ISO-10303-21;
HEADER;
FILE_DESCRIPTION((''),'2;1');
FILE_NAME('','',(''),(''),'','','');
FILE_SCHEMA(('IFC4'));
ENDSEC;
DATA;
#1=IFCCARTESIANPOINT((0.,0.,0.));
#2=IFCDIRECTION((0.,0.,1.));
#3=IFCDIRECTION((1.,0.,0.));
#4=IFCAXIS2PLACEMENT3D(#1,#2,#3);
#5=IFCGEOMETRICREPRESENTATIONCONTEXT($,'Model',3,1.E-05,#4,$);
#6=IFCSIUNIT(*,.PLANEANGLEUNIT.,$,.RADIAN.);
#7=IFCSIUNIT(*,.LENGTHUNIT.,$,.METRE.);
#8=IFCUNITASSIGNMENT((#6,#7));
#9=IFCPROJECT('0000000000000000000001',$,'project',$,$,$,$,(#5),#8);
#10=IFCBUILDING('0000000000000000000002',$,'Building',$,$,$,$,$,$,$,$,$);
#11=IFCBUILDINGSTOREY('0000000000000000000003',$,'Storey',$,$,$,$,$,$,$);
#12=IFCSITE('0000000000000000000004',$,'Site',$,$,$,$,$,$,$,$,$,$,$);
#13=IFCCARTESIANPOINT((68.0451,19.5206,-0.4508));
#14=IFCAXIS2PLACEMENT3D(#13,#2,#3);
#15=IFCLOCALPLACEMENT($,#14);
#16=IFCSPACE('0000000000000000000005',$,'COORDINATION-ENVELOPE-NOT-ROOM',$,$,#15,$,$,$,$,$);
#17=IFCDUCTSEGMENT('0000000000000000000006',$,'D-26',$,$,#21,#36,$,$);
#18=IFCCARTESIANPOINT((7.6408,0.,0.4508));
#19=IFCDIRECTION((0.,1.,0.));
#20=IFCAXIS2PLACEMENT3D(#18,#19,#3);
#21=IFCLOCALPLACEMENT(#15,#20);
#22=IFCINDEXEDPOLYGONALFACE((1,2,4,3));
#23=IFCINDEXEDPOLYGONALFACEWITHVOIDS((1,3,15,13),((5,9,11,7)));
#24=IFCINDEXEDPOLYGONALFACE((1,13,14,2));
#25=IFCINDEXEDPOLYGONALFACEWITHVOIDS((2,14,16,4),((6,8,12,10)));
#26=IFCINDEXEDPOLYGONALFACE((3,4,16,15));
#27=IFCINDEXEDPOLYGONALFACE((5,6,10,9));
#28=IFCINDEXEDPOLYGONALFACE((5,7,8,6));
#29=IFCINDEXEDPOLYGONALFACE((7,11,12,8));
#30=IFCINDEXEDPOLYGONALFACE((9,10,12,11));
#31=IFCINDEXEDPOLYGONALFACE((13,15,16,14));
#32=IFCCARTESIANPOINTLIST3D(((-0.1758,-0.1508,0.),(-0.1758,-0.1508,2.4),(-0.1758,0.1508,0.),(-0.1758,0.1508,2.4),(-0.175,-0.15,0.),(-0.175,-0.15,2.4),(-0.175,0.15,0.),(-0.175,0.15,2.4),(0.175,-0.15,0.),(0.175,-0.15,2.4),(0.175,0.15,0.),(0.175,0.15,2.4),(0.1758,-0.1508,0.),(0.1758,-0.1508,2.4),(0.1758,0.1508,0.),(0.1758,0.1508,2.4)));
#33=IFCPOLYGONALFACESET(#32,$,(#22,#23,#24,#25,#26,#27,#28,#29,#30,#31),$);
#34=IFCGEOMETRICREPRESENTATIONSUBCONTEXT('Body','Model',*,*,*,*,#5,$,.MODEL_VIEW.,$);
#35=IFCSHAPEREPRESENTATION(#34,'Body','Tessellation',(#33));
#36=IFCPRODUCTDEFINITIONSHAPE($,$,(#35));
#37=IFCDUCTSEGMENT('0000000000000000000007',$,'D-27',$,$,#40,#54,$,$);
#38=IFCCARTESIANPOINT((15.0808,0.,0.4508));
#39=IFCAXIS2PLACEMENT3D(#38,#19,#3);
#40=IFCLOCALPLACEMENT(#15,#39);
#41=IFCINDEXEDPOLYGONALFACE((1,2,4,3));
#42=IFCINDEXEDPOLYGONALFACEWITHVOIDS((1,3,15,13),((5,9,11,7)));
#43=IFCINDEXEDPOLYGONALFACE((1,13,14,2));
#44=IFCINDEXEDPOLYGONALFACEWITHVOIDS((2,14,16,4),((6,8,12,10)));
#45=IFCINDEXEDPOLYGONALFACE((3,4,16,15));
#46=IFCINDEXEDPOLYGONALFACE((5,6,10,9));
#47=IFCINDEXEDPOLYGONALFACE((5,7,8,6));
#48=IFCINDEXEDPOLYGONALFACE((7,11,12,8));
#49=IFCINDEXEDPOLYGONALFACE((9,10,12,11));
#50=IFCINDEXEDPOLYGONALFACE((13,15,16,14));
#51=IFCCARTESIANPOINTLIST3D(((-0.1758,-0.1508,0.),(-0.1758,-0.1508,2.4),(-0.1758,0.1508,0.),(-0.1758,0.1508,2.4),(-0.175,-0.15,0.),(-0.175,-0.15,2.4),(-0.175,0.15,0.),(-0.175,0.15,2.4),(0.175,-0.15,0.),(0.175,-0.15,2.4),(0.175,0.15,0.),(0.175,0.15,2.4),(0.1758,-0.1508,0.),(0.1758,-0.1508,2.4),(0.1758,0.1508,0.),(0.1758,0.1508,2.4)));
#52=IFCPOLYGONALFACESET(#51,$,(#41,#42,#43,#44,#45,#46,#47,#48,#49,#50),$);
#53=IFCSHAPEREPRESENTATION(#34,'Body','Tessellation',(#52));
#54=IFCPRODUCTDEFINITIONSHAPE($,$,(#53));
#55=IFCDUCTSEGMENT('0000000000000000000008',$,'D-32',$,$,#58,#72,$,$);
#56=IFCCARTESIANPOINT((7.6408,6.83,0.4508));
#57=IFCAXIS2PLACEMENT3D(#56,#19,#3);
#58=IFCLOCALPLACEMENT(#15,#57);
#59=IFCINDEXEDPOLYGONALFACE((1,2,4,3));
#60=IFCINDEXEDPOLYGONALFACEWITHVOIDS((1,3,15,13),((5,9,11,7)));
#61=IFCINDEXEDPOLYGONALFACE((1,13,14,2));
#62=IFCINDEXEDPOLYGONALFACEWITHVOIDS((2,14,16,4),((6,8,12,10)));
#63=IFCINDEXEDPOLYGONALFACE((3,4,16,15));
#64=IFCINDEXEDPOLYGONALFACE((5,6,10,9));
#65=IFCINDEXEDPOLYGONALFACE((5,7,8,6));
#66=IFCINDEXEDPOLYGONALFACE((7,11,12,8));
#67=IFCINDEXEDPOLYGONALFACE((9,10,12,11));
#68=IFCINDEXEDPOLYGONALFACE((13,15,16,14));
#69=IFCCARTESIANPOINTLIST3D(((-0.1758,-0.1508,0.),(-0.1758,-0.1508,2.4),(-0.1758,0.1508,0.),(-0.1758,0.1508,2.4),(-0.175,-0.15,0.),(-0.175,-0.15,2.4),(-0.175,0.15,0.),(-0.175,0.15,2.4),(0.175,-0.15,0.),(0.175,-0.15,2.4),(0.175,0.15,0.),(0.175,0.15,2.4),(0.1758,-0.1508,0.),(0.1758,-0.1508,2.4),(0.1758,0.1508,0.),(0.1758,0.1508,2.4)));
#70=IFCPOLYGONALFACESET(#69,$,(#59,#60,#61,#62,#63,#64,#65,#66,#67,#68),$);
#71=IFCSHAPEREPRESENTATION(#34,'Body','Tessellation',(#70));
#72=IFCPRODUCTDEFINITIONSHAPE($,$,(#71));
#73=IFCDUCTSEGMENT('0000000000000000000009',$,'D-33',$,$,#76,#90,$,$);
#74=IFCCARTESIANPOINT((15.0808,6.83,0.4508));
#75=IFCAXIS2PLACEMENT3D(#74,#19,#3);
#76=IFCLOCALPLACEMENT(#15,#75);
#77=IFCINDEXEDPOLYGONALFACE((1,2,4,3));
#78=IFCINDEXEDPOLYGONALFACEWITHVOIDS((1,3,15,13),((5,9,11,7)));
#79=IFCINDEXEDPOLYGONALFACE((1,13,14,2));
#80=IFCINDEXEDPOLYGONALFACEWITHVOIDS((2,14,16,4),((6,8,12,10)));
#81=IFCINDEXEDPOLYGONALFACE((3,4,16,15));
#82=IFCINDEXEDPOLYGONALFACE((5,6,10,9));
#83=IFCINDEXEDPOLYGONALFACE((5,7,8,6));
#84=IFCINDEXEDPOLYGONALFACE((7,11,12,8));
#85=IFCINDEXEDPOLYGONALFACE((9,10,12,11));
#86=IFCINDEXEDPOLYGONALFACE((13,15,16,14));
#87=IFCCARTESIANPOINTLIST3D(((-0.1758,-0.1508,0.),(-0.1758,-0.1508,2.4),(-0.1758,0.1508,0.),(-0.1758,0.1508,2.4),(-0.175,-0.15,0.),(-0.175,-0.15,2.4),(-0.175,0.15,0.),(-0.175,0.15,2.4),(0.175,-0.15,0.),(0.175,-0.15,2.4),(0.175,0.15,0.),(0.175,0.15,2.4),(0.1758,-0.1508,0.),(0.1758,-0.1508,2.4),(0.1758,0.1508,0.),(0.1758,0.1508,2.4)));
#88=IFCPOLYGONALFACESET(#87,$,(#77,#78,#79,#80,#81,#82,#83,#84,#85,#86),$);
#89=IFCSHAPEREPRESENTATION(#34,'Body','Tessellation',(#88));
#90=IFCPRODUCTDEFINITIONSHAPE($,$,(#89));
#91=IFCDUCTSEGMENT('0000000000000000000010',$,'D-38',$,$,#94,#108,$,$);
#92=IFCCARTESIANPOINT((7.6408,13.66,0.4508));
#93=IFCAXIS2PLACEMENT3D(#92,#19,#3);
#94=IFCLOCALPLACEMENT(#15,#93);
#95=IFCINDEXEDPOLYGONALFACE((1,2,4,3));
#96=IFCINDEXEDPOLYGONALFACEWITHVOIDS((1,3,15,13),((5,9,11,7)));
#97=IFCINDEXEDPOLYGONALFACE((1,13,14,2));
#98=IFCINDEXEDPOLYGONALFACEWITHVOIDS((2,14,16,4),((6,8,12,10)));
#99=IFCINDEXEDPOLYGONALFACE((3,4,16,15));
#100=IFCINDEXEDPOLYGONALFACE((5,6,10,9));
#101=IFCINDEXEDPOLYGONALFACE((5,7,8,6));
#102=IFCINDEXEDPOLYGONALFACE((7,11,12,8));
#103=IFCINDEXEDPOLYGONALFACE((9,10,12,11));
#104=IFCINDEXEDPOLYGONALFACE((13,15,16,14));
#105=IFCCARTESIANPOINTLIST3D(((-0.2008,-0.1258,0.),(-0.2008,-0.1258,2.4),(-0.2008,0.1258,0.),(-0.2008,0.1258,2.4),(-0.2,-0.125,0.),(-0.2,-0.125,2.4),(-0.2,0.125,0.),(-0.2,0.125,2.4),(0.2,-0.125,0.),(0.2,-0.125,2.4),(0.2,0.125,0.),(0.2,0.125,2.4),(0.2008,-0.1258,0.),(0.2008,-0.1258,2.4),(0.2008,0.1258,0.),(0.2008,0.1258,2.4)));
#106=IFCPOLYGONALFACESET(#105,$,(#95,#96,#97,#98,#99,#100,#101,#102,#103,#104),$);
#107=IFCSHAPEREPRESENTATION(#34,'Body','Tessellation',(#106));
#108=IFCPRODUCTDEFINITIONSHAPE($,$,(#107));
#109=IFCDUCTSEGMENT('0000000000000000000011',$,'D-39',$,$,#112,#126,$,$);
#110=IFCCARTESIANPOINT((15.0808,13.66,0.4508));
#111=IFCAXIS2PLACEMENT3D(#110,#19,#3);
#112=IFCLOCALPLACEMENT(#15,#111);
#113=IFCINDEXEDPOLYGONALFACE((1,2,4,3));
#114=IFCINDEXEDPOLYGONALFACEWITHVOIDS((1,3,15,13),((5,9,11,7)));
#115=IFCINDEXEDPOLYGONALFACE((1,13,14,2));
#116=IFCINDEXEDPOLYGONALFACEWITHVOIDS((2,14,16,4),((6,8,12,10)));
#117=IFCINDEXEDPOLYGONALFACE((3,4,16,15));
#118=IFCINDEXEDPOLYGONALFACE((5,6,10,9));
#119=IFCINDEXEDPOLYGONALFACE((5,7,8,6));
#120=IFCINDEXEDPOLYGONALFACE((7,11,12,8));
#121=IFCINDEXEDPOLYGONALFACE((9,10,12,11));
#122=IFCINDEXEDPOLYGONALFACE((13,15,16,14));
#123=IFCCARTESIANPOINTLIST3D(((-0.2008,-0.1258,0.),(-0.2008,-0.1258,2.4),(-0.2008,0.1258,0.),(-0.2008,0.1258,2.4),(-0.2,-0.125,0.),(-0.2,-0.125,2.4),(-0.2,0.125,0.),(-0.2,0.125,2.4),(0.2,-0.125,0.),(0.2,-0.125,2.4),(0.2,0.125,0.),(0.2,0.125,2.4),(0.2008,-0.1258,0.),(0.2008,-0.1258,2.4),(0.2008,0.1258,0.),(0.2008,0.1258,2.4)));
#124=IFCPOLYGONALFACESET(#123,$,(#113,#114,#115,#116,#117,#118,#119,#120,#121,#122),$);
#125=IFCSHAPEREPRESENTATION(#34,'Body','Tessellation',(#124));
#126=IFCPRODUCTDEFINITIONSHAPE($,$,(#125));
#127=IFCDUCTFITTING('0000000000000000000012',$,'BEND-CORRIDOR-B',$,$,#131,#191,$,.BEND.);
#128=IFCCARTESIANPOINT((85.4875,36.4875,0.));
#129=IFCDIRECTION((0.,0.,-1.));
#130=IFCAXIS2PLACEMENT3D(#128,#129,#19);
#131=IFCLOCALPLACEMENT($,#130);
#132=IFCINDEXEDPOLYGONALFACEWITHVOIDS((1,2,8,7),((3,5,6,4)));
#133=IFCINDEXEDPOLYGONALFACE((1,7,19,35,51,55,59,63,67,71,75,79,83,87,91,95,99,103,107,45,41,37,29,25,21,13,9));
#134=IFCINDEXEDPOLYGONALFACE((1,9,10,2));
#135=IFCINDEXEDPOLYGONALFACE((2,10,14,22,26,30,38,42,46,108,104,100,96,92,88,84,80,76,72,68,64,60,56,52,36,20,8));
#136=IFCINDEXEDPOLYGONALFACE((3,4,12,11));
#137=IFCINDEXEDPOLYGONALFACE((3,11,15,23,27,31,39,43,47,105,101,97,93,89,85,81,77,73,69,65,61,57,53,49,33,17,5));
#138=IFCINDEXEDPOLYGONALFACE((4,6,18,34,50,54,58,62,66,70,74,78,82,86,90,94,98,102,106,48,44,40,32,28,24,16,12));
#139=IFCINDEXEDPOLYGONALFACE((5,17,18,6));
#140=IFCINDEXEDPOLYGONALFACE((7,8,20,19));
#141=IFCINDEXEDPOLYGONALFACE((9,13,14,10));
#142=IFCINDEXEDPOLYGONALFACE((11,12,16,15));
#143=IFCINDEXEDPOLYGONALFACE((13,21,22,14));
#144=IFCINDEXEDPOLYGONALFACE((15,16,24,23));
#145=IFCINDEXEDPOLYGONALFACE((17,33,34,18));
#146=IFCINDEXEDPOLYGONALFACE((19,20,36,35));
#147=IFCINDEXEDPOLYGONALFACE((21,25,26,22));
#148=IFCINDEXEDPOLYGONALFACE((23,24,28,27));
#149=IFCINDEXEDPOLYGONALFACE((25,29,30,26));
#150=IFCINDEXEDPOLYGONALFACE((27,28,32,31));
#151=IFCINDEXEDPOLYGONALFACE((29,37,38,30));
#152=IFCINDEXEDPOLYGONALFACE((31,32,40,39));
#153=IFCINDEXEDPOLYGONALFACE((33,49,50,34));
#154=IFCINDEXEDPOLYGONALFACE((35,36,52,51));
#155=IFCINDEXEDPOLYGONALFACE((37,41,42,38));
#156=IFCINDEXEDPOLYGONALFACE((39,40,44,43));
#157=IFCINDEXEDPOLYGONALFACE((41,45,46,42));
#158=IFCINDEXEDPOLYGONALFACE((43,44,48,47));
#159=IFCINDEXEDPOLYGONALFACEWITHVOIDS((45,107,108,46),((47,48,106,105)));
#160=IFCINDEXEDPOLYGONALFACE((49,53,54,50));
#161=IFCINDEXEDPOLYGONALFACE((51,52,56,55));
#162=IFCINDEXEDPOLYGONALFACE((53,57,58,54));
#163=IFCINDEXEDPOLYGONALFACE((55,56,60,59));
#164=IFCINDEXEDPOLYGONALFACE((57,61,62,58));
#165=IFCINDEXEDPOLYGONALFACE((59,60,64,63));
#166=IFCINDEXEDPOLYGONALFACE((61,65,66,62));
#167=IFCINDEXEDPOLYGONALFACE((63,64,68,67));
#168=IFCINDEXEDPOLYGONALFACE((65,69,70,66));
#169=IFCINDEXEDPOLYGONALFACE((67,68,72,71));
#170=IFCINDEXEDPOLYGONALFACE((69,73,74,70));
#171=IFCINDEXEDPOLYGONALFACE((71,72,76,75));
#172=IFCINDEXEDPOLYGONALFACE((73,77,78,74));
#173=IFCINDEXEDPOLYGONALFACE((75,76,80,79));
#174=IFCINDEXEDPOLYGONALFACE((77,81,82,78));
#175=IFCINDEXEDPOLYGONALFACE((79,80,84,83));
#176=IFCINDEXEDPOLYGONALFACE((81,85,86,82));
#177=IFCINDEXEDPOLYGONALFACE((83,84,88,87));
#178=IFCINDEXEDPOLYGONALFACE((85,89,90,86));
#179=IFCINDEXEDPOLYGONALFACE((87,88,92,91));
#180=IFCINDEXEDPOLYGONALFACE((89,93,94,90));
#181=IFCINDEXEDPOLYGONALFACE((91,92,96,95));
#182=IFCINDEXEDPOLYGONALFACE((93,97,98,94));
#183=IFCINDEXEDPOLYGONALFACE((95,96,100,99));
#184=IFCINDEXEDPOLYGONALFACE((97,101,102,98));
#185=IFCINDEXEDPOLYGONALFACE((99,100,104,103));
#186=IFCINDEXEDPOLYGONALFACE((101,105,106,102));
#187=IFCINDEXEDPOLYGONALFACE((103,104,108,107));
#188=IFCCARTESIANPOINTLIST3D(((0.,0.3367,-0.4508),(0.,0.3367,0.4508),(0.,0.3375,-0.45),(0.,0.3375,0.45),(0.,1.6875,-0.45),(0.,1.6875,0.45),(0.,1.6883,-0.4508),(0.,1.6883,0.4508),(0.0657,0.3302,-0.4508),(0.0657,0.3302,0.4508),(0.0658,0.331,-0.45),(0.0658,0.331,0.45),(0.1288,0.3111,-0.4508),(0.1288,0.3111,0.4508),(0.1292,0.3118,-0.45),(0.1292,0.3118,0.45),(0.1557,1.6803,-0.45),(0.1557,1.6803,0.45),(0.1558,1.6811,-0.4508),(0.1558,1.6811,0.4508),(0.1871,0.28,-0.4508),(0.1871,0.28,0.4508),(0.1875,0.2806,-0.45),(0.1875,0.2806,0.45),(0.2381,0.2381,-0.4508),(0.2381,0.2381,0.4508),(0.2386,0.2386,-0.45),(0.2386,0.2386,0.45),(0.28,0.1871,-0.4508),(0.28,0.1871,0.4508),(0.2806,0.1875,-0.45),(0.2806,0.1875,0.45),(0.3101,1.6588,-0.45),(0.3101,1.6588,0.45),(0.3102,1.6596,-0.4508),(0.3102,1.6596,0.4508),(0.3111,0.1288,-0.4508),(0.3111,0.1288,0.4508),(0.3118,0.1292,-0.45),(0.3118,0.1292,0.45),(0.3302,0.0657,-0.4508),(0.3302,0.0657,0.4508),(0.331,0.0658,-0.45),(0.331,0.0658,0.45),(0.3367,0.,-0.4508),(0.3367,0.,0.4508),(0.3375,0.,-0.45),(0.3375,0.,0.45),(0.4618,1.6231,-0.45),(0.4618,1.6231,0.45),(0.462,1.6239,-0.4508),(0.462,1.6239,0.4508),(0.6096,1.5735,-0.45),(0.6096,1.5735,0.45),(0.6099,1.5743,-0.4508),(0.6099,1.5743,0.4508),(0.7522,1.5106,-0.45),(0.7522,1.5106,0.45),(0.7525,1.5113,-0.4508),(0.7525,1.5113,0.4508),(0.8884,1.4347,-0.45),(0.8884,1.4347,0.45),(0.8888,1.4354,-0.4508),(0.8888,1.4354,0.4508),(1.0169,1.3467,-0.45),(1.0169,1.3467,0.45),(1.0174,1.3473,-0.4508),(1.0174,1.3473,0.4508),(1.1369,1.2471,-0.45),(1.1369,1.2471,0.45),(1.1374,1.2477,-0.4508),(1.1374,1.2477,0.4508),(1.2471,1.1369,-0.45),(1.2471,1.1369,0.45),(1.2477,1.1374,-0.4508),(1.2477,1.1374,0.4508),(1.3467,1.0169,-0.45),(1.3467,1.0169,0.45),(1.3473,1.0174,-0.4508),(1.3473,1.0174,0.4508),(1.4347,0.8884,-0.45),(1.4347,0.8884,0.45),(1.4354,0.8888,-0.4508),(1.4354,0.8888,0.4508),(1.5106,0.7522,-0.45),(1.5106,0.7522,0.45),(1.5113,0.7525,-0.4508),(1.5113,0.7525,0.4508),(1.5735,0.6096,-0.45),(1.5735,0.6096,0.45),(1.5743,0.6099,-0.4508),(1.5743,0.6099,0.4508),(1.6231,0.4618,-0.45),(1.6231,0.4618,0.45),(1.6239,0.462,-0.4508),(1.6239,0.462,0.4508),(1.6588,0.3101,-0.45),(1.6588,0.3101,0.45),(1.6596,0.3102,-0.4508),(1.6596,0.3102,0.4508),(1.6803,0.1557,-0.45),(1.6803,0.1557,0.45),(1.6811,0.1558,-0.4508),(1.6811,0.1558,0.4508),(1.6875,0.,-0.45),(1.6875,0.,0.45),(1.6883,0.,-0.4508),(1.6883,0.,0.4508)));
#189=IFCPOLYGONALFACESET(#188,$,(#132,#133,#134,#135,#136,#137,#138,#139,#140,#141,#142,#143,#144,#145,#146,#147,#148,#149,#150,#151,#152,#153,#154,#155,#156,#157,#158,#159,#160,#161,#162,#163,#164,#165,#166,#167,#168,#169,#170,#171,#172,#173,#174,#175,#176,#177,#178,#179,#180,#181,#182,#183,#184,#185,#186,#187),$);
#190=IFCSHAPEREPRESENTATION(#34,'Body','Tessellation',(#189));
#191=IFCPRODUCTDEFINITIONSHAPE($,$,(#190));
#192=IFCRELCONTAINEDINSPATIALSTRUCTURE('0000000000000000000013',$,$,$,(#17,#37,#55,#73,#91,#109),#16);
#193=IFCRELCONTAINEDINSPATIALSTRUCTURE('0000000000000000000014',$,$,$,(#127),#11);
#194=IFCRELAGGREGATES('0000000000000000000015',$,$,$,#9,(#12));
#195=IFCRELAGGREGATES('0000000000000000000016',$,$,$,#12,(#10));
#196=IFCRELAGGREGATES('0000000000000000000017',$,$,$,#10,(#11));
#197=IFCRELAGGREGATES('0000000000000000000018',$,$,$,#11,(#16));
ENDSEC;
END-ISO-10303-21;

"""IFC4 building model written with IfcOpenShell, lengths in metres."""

from ifc_helpers import new_model, entity, si_unit, frame, origin, origin_with_axes, place, context, subcontext, project, spatial, hollow_rectangle, extrude, element, save


model = new_model("IFC4")

# Units and contexts
model_context = context("Model", 3, precision=1e-05, world=origin_with_axes())
body_context = subcontext(model_context, "Body", "Model", "MODEL_VIEW")
ifc_project = project(units=[si_unit("PLANEANGLEUNIT", "RADIAN"), si_unit("LENGTHUNIT", "METRE")], contexts=[model_context])

# Site, building, storey, space
site = spatial("IfcSite", under=ifc_project, Name="Site")
building = spatial("IfcBuilding", under=site, Name="Building")
storey = spatial("IfcBuildingStorey", under=building, Name="Storey")
space_placement = place(None, frame((68.0451, 19.5206, -0.4508), z_axis=(0.0, 0.0, 1.0), x_axis=(1.0, 0.0, 0.0)))
space = spatial("IfcSpace", under=storey, at=space_placement, Name="COORDINATION-ENVELOPE-NOT-ROOM")

# Duct segments
for number, where, z_axis, x_axis, name in (
    (1, (7.6408, 0.0, 0.4508), (0.0, 1.0, 0.0), (1.0, 0.0, 0.0), "D-26"),
    (2, (15.0808, 0.0, 0.4508), (0.0, 1.0, 0.0), (1.0, 0.0, 0.0), "D-27"),
):
    element("IfcDuctSegment", number, at=place(space_placement, frame(where, z_axis=z_axis, x_axis=x_axis)), inside=space, Name=name, context=body_context, shape_type="SweptSolid", body=[
        extrude(hollow_rectangle(XDim=0.3516, YDim=0.3016, WallThickness=0.0008), origin(), (0.0, 0.0, 1.0), 2.4),
    ])
for number, where, z_axis, x_axis, name in (
    (3, (7.6408, 6.83, 0.4508), (0.0, 1.0, 0.0), (1.0, 0.0, 0.0), "D-32"),
    (4, (15.0808, 6.83, 0.4508), (0.0, 1.0, 0.0), (1.0, 0.0, 0.0), "D-33"),
):
    element("IfcDuctSegment", number, at=place(space_placement, frame(where, z_axis=z_axis, x_axis=x_axis)), inside=space, Name=name, context=body_context, shape_type="SweptSolid", body=[
        extrude(hollow_rectangle(XDim=0.3516, YDim=0.3016, WallThickness=0.0008), origin(), (0.0, 0.0, 1.0), 2.4),
    ])
for number, where, z_axis, x_axis, name in (
    (5, (7.6408, 13.66, 0.4508), (0.0, 1.0, 0.0), (1.0, 0.0, 0.0), "D-38"),
    (6, (15.0808, 13.66, 0.4508), (0.0, 1.0, 0.0), (1.0, 0.0, 0.0), "D-39"),
):
    element("IfcDuctSegment", number, at=place(space_placement, frame(where, z_axis=z_axis, x_axis=x_axis)), inside=space, Name=name, context=body_context, shape_type="SweptSolid", body=[
        extrude(hollow_rectangle(XDim=0.4016, YDim=0.2516, WallThickness=0.0008), origin(), (0.0, 0.0, 1.0), 2.4),
    ])

# Duct fitting
duct_fitting_1_placement = place(None, frame((85.4875, 36.4875, 0.0), z_axis=(0.0, 0.0, -1.0), x_axis=(0.0, 1.0, 0.0)))
cartesian_point_1 = entity("IfcCartesianPoint", [0.0, 0.0, 0.0])
element("IfcDuctFitting", 7, at=duct_fitting_1_placement, inside=storey, Name="BEND-CORRIDOR-B", PredefinedType="BEND", context=body_context, shape_type="SweptSolid", body=[
    entity("IfcRevolvedAreaSolid", entity("IfcRectangleHollowProfileDef", "AREA", None, entity("IfcAxis2Placement2D", entity("IfcCartesianPoint", [1.0125, 0.0])), 1.3516, 0.9016, 0.0008), entity("IfcAxis2Placement3D", cartesian_point_1, entity("IfcDirection", [0.0, -1.0, 0.0]), entity("IfcDirection", [1.0, 0.0, 0.0])), entity("IfcAxis1Placement", cartesian_point_1, entity("IfcDirection", [0.0, 1.0, 0.0])), 1.570796),
])

save(model, "model.ifc")
